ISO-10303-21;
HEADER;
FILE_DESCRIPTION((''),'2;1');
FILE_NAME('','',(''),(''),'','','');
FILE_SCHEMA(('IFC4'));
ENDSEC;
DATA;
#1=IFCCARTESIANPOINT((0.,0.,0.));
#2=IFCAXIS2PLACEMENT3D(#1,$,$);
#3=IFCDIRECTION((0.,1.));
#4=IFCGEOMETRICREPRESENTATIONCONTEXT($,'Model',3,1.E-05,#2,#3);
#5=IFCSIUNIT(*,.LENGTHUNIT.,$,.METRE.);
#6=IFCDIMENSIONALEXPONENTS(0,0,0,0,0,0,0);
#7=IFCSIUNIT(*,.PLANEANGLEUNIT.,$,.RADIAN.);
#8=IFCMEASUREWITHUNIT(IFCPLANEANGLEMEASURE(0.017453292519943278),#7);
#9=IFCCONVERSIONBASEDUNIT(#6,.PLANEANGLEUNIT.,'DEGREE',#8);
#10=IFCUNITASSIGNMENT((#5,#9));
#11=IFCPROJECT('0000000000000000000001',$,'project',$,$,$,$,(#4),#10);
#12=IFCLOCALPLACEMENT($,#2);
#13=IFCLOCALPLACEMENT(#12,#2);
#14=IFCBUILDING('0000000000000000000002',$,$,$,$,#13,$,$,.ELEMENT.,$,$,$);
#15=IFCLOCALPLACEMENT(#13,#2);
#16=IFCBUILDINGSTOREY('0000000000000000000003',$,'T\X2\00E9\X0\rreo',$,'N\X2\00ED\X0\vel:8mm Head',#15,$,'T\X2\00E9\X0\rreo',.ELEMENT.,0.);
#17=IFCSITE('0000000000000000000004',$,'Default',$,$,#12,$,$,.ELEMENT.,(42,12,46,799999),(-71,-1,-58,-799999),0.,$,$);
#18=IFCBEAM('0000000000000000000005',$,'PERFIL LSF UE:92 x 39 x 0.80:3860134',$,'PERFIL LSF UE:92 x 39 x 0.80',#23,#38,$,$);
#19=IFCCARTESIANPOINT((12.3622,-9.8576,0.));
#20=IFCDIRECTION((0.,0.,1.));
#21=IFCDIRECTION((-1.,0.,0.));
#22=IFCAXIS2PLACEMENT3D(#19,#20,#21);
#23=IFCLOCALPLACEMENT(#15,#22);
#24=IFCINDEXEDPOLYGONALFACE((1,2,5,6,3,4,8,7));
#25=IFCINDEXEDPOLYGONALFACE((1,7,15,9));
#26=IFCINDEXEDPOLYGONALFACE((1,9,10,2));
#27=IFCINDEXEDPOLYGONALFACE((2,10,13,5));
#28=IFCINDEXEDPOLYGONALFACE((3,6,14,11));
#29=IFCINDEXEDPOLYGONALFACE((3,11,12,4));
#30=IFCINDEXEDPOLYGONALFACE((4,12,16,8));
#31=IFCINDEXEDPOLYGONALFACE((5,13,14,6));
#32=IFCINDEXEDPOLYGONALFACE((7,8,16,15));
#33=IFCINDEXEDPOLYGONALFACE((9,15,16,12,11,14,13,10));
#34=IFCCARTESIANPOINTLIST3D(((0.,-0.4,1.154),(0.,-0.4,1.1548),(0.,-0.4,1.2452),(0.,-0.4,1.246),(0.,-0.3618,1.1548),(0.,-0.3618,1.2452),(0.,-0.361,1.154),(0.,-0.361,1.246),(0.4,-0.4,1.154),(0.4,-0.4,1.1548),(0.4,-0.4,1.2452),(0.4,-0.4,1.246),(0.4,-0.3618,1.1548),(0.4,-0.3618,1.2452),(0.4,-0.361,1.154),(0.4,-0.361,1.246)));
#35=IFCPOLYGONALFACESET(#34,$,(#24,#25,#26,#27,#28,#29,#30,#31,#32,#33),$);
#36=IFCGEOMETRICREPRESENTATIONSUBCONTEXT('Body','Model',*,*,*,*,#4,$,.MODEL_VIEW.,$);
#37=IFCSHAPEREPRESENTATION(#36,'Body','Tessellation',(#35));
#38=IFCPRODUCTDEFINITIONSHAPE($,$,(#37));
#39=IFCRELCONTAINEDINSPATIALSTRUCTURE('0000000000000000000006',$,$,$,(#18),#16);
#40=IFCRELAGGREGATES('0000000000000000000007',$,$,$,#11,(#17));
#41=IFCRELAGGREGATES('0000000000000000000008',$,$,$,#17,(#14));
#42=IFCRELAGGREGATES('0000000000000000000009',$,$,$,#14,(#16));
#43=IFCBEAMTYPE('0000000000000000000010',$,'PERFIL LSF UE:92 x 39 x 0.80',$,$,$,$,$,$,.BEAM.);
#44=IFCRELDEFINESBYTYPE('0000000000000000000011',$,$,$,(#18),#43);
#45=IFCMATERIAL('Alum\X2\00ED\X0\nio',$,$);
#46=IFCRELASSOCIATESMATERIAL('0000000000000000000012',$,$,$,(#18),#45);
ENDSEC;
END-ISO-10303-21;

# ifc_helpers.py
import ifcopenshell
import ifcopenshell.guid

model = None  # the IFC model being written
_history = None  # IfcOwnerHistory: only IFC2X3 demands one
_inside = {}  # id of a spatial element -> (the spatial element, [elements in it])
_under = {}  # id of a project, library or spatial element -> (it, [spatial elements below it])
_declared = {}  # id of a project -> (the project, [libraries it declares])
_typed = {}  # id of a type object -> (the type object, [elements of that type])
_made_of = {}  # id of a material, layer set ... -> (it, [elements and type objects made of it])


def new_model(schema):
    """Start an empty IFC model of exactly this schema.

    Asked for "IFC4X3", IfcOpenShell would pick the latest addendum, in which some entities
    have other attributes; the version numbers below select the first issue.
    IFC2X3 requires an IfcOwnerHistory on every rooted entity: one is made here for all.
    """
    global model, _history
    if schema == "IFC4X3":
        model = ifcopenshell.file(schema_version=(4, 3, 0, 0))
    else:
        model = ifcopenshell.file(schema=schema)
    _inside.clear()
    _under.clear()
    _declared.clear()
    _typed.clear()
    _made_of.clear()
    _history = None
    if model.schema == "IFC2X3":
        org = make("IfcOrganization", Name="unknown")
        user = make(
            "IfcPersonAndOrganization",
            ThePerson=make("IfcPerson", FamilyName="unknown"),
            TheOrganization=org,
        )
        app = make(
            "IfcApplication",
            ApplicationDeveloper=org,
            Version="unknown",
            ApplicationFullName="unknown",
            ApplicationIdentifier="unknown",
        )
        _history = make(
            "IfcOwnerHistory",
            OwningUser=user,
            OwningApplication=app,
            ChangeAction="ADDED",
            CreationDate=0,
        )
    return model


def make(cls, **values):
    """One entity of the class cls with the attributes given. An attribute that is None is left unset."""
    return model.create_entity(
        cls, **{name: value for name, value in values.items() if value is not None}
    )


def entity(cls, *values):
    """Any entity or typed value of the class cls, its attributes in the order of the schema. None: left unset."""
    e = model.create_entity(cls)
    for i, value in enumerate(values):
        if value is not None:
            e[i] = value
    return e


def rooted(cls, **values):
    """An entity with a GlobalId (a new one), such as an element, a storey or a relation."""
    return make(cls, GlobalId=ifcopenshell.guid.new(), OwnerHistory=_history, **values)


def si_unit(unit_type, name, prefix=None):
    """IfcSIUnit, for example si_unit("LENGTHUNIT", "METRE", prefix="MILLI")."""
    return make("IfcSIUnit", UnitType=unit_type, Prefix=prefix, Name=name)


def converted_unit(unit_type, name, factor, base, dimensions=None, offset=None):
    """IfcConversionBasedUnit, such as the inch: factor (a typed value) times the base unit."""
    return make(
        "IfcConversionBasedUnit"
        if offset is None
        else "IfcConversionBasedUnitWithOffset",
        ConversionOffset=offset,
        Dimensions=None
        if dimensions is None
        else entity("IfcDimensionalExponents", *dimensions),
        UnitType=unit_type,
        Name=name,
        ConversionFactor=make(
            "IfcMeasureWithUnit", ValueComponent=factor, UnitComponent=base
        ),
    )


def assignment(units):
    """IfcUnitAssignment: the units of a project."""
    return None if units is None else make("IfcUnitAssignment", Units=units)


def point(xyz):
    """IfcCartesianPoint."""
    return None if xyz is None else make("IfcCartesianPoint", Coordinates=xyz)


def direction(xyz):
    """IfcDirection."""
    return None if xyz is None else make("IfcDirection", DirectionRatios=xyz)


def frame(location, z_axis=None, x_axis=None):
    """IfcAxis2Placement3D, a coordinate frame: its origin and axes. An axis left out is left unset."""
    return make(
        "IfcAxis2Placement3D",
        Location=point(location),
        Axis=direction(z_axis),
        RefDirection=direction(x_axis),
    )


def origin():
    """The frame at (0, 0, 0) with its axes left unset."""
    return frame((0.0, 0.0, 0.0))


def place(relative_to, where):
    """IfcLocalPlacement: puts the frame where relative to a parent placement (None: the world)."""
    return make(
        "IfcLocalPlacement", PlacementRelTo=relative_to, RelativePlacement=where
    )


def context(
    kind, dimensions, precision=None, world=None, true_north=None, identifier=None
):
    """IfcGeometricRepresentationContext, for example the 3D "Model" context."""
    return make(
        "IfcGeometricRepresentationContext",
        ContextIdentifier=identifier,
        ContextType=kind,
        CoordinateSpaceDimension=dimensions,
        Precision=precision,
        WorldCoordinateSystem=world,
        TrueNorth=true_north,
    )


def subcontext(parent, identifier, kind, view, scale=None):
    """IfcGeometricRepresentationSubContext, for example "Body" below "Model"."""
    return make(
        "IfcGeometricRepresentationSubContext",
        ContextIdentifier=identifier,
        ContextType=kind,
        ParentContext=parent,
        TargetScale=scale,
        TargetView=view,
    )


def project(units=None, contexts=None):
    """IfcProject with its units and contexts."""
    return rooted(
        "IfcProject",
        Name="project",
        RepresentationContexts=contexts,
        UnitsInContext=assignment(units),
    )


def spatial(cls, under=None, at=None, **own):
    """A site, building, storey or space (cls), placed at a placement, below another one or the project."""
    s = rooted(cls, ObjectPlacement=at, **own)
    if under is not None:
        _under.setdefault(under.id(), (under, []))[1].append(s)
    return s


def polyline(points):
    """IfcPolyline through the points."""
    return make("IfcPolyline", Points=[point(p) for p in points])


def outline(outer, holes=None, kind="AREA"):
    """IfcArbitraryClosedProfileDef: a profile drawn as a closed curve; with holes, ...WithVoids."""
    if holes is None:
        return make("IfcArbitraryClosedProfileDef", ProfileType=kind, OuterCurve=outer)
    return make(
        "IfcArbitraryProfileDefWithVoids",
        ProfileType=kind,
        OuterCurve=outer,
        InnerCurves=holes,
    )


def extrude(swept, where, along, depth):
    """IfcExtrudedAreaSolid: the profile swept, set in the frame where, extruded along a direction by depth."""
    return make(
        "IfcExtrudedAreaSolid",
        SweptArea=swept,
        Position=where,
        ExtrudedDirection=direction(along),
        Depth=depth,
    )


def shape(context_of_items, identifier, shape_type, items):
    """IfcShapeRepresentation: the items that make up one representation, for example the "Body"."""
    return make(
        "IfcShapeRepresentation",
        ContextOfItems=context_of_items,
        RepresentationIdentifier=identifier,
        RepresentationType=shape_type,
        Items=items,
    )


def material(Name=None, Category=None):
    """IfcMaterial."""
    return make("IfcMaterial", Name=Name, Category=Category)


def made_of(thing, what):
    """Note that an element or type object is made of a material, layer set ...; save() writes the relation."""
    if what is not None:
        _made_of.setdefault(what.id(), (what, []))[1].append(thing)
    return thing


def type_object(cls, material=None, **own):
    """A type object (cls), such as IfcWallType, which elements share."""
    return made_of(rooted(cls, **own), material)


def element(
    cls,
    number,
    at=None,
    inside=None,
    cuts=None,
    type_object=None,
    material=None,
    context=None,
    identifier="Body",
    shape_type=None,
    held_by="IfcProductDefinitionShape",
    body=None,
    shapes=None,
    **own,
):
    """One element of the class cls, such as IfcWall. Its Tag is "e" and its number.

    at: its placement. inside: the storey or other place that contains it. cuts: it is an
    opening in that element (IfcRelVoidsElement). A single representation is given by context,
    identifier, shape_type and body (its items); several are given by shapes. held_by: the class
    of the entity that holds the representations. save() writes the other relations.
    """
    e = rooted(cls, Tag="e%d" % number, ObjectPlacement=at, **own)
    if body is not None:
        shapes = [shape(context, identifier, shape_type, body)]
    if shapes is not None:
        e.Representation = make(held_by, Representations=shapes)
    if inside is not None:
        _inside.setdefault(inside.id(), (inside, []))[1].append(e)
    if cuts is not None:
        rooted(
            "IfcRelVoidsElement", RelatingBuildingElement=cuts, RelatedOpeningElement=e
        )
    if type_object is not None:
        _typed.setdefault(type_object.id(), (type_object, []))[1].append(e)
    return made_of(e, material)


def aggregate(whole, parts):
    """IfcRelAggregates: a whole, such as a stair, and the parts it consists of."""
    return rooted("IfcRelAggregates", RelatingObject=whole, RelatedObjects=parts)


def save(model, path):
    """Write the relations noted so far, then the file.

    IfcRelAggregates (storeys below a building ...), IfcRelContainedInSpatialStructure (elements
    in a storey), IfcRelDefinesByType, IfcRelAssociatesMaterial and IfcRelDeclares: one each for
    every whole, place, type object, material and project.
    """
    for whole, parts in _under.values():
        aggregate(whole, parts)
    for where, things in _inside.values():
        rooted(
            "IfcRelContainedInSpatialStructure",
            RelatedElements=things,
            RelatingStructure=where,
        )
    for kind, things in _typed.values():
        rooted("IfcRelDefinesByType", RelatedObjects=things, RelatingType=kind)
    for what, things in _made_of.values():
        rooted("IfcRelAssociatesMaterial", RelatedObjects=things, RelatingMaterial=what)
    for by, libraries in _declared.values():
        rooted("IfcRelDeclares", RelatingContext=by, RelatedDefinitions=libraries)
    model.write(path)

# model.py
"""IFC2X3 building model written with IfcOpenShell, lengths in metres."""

from ifc_helpers import new_model, entity, si_unit, converted_unit, direction, frame, origin, place, context, subcontext, project, spatial, polyline, outline, extrude, material, type_object, element, save


model = new_model("IFC2X3")

# Units and contexts
model_context = context("Model", 3, precision=1e-05, world=origin(), true_north=direction((0.0, 1.0)))
body_context = subcontext(model_context, "Body", "Model", "MODEL_VIEW")
ifc_project = project(units=[si_unit("LENGTHUNIT", "METRE"), converted_unit("PLANEANGLEUNIT", "DEGREE", entity("IfcPlaneAngleMeasure", 0.017453292519943278), si_unit("PLANEANGLEUNIT", "RADIAN"), dimensions=[0, 0, 0, 0, 0, 0, 0])], contexts=[model_context])

# Site, building, storey
site_placement = place(None, origin())
site = spatial("IfcSite", under=ifc_project, at=site_placement, Name="Default", CompositionType="ELEMENT", RefLatitude=(42, 12, 46, 799999), RefLongitude=(-71, -1, -58, -799999), RefElevation=0.0)
building_placement = place(site_placement, origin())
building = spatial("IfcBuilding", under=site, at=building_placement, CompositionType="ELEMENT")
storey_placement = place(building_placement, origin())
storey = spatial("IfcBuildingStorey", under=building, at=storey_placement, Name="Térreo", ObjectType="Nível:8mm Head", LongName="Térreo", CompositionType="ELEMENT", Elevation=0.0)

# Beam
ifc_material_1 = material(Name="Alumínio")
beam_type = type_object("IfcBeamType", Name="PERFIL LSF UE:92 x 39 x 0.80", PredefinedType="BEAM")
for number, where, z_axis, x_axis, name in (
    (1, (12.3622, -9.8576, 0.0), (0.0, 0.0, 1.0), (-1.0, 0.0, 0.0), "PERFIL LSF UE:92 x 39 x 0.80:3860134"),
):
    element("IfcBeam", number, at=place(storey_placement, frame(where, z_axis=z_axis, x_axis=x_axis)), inside=storey, type_object=beam_type, material=ifc_material_1, Name=name, ObjectType="PERFIL LSF UE:92 x 39 x 0.80", context=body_context, shape_type="SweptSolid", body=[
        extrude(outline(polyline([(-0.046, -0.0193), (-0.0452, -0.0193), (-0.0452, 0.0189), (0.0452, 0.0189), (0.0452, -0.0193), (0.046, -0.0193), (0.046, 0.0197), (-0.046, 0.0197), (-0.046, -0.0193)])), frame((0.0, -0.3807, 1.2), z_axis=(1.0, 0.0, 0.0), x_axis=(0.0, 0.0, -1.0)), (0.0, 0.0, 1.0), 0.4),
    ])

save(model, "model.ifc")
